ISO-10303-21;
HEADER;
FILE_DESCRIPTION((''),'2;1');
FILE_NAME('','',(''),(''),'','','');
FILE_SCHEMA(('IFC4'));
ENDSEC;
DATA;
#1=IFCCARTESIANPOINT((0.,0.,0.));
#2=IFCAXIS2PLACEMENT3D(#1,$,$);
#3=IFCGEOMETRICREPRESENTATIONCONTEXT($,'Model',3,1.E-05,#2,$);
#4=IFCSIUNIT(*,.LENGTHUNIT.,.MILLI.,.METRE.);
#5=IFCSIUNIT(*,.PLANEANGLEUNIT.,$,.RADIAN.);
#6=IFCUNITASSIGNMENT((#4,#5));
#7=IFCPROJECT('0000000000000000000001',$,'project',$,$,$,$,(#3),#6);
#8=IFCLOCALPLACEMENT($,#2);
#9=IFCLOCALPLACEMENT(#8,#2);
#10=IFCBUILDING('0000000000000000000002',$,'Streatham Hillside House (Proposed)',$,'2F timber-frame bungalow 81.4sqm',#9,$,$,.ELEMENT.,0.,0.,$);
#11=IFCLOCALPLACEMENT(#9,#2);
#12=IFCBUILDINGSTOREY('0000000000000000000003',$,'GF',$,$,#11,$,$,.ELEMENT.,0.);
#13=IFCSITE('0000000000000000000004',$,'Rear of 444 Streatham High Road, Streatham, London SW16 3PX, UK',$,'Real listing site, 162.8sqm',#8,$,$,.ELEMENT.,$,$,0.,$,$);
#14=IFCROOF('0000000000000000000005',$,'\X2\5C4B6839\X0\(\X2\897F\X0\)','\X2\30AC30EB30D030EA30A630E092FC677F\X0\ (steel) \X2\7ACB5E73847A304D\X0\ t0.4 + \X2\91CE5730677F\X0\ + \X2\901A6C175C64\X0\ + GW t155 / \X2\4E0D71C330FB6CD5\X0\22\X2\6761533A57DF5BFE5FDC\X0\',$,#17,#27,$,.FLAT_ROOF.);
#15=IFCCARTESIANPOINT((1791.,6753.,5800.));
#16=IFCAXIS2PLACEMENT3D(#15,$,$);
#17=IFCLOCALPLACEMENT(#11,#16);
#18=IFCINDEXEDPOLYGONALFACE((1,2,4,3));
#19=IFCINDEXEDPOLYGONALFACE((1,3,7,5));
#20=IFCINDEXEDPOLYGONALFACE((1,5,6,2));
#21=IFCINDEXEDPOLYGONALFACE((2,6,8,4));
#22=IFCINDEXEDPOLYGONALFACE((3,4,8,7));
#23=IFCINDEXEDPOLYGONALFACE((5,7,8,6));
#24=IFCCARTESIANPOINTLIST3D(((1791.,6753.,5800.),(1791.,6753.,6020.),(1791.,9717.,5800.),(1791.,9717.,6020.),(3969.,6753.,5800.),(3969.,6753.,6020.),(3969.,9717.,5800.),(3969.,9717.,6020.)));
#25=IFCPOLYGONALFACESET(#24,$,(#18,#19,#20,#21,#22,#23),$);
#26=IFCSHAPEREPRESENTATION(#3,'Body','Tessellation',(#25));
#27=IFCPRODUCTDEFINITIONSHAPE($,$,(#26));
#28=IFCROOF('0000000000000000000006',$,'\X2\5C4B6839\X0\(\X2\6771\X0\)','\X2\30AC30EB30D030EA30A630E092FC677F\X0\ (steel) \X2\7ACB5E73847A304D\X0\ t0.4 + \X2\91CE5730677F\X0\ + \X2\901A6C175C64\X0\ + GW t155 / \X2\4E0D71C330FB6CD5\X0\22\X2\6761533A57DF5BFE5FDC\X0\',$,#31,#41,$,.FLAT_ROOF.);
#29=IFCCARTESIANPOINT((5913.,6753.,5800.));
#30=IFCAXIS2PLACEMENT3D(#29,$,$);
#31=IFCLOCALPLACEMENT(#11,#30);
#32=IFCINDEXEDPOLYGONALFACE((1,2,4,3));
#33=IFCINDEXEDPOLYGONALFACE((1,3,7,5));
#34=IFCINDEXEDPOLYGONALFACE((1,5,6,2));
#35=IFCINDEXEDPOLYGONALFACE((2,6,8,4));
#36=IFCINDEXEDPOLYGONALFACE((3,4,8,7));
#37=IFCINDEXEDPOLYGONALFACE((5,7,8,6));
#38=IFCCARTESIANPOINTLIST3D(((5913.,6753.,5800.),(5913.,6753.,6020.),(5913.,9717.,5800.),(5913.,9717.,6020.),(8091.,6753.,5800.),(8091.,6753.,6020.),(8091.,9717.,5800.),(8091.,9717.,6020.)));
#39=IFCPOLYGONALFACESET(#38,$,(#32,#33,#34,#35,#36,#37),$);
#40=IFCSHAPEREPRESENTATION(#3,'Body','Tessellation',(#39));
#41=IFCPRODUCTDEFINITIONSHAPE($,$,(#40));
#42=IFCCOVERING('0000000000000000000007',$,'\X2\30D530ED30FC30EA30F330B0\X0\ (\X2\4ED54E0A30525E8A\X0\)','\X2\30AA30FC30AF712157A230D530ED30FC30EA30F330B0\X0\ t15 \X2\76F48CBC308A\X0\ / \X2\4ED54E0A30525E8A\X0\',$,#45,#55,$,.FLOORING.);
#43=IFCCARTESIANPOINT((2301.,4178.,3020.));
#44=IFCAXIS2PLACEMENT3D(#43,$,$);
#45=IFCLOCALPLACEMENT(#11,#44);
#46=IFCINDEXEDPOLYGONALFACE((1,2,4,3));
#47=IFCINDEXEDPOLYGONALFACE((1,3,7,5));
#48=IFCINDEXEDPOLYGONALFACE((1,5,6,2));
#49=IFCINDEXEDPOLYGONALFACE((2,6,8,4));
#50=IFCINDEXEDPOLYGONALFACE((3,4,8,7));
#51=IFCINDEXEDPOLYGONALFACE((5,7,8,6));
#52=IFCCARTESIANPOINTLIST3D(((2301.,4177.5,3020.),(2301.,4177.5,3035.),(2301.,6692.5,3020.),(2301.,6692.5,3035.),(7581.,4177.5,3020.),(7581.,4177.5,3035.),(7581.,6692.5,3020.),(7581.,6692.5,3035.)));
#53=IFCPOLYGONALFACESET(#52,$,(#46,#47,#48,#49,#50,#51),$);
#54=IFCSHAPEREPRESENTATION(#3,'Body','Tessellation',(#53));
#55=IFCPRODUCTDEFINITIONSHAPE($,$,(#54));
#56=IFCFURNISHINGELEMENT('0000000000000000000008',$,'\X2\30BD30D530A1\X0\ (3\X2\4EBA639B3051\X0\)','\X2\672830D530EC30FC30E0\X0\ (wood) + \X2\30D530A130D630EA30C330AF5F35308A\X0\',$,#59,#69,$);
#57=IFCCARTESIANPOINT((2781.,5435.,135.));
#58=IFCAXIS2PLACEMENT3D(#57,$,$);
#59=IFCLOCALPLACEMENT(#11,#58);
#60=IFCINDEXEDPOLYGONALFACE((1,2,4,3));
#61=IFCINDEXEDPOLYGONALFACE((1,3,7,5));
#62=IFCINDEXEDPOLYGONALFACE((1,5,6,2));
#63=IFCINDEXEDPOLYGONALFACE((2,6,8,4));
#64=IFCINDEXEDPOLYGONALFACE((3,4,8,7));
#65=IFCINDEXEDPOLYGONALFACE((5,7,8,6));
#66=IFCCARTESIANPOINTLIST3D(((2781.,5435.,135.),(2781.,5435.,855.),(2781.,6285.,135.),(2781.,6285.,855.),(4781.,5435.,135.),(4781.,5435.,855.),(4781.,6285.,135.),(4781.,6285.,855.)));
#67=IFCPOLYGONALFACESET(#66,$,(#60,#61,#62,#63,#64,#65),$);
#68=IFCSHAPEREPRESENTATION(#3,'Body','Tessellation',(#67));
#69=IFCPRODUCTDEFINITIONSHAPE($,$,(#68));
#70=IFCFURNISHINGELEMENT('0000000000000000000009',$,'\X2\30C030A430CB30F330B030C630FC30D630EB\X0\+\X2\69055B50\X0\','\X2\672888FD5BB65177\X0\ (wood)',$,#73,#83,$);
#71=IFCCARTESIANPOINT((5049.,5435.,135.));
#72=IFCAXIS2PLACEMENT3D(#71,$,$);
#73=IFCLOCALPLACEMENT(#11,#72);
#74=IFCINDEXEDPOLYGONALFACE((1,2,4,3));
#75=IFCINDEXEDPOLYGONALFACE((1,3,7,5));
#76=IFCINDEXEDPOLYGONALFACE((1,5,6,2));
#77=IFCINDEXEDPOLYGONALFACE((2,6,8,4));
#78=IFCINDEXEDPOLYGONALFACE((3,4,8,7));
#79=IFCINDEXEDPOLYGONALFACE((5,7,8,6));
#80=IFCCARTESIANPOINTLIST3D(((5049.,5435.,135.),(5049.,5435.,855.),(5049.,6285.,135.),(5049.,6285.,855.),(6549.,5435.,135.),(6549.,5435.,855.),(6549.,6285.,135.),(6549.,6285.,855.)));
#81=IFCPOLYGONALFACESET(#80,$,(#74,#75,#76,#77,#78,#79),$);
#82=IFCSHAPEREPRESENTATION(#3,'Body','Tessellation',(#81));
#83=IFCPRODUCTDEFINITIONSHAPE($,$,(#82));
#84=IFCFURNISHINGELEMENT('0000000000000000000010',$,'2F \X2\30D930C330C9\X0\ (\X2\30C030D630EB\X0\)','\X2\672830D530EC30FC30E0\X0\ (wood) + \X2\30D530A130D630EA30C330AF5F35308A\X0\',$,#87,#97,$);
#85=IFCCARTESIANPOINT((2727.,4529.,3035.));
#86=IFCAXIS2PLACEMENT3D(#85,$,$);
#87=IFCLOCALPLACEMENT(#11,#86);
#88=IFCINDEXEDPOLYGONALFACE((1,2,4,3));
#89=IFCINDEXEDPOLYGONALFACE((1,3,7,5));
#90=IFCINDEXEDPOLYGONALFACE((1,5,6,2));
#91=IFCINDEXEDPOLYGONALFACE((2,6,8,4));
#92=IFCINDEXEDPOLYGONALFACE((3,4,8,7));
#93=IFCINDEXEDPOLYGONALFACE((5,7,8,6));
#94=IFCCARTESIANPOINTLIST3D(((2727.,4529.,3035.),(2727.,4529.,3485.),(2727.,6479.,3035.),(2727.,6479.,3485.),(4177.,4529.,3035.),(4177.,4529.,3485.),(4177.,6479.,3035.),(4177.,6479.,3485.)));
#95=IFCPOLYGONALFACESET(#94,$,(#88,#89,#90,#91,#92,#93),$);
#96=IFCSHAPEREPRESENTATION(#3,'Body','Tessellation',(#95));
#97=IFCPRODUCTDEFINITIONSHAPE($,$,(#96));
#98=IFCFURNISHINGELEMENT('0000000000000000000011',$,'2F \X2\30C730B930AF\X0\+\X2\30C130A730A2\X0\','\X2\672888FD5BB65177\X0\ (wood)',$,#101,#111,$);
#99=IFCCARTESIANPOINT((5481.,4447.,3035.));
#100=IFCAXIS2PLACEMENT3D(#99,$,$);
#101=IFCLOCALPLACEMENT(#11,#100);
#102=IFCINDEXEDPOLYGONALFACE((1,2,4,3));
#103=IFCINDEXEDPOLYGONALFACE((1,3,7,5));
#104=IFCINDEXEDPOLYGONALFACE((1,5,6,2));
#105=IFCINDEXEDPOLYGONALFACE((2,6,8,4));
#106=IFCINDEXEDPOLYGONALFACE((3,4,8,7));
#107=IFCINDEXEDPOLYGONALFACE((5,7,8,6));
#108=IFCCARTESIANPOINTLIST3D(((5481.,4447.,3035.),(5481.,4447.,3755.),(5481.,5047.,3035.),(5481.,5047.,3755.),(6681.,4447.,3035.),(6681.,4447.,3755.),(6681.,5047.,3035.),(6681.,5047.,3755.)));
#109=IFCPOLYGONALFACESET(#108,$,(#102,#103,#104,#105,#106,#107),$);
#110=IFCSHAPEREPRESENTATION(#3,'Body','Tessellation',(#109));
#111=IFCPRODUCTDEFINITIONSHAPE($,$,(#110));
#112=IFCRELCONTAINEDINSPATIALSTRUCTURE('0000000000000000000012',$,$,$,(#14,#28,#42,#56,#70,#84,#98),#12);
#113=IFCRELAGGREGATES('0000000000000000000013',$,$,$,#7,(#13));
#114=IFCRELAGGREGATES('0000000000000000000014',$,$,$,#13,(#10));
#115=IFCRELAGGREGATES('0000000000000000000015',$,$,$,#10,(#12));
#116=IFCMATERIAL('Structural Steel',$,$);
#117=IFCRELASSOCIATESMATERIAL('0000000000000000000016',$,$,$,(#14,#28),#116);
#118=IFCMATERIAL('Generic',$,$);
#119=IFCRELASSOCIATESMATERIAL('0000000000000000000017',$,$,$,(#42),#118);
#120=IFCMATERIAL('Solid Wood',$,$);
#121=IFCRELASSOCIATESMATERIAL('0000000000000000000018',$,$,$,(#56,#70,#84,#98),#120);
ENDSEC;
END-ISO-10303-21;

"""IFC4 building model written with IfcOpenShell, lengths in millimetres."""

from ifc_helpers import new_model, si_unit, frame, frame_2d, origin, place, context, project, spatial, rectangle, extrude, material, element, save


model = new_model("IFC4")

# Units and contexts
model_context = context("Model", 3, precision=1e-05, world=origin())
ifc_project = project(units=[si_unit("LENGTHUNIT", "METRE", prefix="MILLI"), si_unit("PLANEANGLEUNIT", "RADIAN")], contexts=[model_context])

# Site, building, storey
site_placement = place(None, origin())
site = spatial("IfcSite", under=ifc_project, at=site_placement, Name="Rear of 444 Streatham High Road, Streatham, London SW16 3PX, UK", ObjectType="Real listing site, 162.8sqm", CompositionType="ELEMENT", RefElevation=0.0)
building_placement = place(site_placement, origin())
building = spatial("IfcBuilding", under=site, at=building_placement, Name="Streatham Hillside House (Proposed)", ObjectType="2F timber-frame bungalow 81.4sqm", CompositionType="ELEMENT", ElevationOfRefHeight=0.0, ElevationOfTerrain=0.0)
storey_placement = place(building_placement, origin())
storey = spatial("IfcBuildingStorey", under=building, at=storey_placement, Name="GF", CompositionType="ELEMENT", Elevation=0.0)

# Shared definitions
ifc_material_1 = material(Name="Solid Wood")

# Roofs
ifc_material_2 = material(Name="Structural Steel")
roof_1_placement = place(storey_placement, frame((1791.0, 6753.0, 5800.0)))
element("IfcRoof", 1, at=roof_1_placement, inside=storey, material=ifc_material_2, Name="屋根(西)", Description="ガルバリウム鋼板 (steel) 立平葺き t0.4 + 野地板 + 通気層 + GW t155 / 不燃・法22条区域対応", PredefinedType="FLAT_ROOF", context=model_context, shape_type="SweptSolid", body=[
    extrude(rectangle(XDim=2178.0, YDim=2964.0, at=frame_2d((1089.0, 1482.0))), frame((1791.0, 6753.0, 5800.0)), (0.0, 0.0, 1.0), 220.0),
])
roof_2_placement = place(storey_placement, frame((5913.0, 6753.0, 5800.0)))
element("IfcRoof", 2, at=roof_2_placement, inside=storey, material=ifc_material_2, Name="屋根(東)", Description="ガルバリウム鋼板 (steel) 立平葺き t0.4 + 野地板 + 通気層 + GW t155 / 不燃・法22条区域対応", PredefinedType="FLAT_ROOF", context=model_context, shape_type="SweptSolid", body=[
    extrude(rectangle(XDim=2178.0, YDim=2964.0, at=frame_2d((1089.0, 1482.0))), frame((5913.0, 6753.0, 5800.0)), (0.0, 0.0, 1.0), 220.0),
])

# Covering
ifc_material_3 = material(Name="Generic")
covering_placement = place(storey_placement, frame((2301.0, 4178.0, 3020.0)))
element("IfcCovering", 3, at=covering_placement, inside=storey, material=ifc_material_3, Name="フローリング (仕上げ床)", Description="オーク無垢フローリング t15 直貼り / 仕上げ床", PredefinedType="FLOORING", context=model_context, shape_type="SweptSolid", body=[
    extrude(rectangle(XDim=5280.0, YDim=2515.0, at=frame_2d((2640.0, 1257.0))), frame((2301.0, 4178.0, 3020.0)), (0.0, 0.0, 1.0), 15.0),
])

# Furnishing elements
furnishing_1_placement = place(storey_placement, frame((2781.0, 5435.0, 135.0)))
element("IfcFurnishingElement", 4, at=furnishing_1_placement, inside=storey, material=ifc_material_1, Name="ソファ (3人掛け)", Description="木フレーム (wood) + ファブリック張り", context=model_context, shape_type="SweptSolid", body=[
    extrude(rectangle(XDim=2000.0, YDim=850.0, at=frame_2d((1000.0, 425.0))), frame((2781.0, 5435.0, 135.0)), (0.0, 0.0, 1.0), 720.0),
])
furnishing_2_placement = place(storey_placement, frame((5049.0, 5435.0, 135.0)))
element("IfcFurnishingElement", 5, at=furnishing_2_placement, inside=storey, material=ifc_material_1, Name="ダイニングテーブル+椅子", Description="木製家具 (wood)", context=model_context, shape_type="SweptSolid", body=[
    extrude(rectangle(XDim=1500.0, YDim=850.0, at=frame_2d((750.0, 425.0))), frame((5049.0, 5435.0, 135.0)), (0.0, 0.0, 1.0), 720.0),
])
furnishing_3_placement = place(storey_placement, frame((2727.0, 4529.0, 3035.0)))
element("IfcFurnishingElement", 6, at=furnishing_3_placement, inside=storey, material=ifc_material_1, Name="2F ベッド (ダブル)", Description="木フレーム (wood) + ファブリック張り", context=model_context, shape_type="SweptSolid", body=[
    extrude(rectangle(XDim=1450.0, YDim=1950.0, at=frame_2d((725.0, 975.0))), frame((2727.0, 4529.0, 3035.0)), (0.0, 0.0, 1.0), 450.0),
])
furnishing_4_placement = place(storey_placement, frame((5481.0, 4447.0, 3035.0)))
element("IfcFurnishingElement", 7, at=furnishing_4_placement, inside=storey, material=ifc_material_1, Name="2F デスク+チェア", Description="木製家具 (wood)", context=model_context, shape_type="SweptSolid", body=[
    extrude(rectangle(XDim=1200.0, YDim=600.0, at=frame_2d((600.0, 300.0))), frame((5481.0, 4447.0, 3035.0)), (0.0, 0.0, 1.0), 720.0),
])

save(model, "model.ifc")
